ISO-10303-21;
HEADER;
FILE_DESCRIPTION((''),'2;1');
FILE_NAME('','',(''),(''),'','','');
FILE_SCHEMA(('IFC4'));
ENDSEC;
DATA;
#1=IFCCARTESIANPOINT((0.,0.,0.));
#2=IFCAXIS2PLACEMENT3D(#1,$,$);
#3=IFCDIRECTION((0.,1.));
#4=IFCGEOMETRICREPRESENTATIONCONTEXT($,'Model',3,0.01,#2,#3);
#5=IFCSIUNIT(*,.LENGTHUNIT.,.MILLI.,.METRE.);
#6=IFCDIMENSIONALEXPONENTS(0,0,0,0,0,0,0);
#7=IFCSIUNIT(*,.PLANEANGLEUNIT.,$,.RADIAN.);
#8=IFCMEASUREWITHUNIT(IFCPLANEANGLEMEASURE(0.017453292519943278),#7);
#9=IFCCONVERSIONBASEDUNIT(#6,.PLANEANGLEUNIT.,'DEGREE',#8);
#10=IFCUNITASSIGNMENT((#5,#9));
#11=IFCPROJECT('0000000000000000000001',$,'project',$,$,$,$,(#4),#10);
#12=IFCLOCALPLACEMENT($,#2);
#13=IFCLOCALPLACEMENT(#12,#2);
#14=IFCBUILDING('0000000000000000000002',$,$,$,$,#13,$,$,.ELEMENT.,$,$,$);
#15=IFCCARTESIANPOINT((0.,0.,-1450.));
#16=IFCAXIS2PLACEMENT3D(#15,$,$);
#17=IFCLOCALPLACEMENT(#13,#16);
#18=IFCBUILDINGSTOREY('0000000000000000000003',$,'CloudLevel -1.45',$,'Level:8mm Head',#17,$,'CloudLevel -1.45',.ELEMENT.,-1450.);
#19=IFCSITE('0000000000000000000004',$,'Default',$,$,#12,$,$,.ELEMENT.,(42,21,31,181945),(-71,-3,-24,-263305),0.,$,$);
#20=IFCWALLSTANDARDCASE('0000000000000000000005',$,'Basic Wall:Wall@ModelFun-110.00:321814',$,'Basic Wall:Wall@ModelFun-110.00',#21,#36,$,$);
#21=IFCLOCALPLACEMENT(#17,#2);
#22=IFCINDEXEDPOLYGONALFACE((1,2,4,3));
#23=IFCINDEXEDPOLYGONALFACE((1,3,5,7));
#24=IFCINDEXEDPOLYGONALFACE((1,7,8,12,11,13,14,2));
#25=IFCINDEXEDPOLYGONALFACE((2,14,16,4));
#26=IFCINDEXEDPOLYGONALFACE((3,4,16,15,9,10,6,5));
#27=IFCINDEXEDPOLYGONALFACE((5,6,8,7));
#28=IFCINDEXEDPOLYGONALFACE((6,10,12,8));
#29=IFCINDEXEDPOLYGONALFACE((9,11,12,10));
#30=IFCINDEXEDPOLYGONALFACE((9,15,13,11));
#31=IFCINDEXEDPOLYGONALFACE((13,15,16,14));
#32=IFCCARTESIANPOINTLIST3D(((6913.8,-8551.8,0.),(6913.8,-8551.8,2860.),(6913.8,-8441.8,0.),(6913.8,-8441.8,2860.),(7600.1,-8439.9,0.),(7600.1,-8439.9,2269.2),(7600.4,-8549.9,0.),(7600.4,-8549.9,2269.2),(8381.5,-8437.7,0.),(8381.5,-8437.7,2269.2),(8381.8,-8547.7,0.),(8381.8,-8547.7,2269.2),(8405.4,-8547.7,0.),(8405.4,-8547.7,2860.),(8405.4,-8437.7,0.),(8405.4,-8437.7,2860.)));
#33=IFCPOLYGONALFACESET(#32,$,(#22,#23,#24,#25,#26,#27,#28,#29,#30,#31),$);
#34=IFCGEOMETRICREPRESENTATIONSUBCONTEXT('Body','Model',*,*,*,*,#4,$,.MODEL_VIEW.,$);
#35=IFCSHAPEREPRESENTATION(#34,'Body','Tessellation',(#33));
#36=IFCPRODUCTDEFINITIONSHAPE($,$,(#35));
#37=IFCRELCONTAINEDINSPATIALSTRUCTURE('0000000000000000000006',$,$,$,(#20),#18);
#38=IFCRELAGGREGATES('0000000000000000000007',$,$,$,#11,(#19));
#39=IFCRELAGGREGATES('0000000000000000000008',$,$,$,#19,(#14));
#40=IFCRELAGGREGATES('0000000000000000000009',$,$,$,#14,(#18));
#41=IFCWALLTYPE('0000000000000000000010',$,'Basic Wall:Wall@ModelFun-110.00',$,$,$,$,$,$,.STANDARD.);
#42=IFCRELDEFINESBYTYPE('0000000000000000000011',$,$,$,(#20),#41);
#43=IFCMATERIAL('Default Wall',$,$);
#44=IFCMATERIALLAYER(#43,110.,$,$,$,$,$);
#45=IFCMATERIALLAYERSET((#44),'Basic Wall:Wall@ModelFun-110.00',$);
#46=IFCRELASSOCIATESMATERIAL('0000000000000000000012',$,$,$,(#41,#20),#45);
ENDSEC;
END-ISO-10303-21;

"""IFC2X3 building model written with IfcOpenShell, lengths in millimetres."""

from ifc_helpers import new_model, entity, si_unit, converted_unit, direction, frame, frame_2d, origin, place, context, subcontext, project, spatial, polyline, rectangle, outline, extrude, material, layer, layer_set, layer_usage, type_object, element, save


model = new_model("IFC2X3")

# Units and contexts
model_context = context("Model", 3, precision=0.01, world=origin(), true_north=direction((0.0, 1.0)))
body_context = subcontext(model_context, "Body", "Model", "MODEL_VIEW")
ifc_project = project(units=[si_unit("LENGTHUNIT", "METRE", prefix="MILLI"), converted_unit("PLANEANGLEUNIT", "DEGREE", entity("IfcPlaneAngleMeasure", 0.017453292519943278), si_unit("PLANEANGLEUNIT", "RADIAN"), dimensions=[0, 0, 0, 0, 0, 0, 0])], contexts=[model_context])

# Site, building, storey
site_placement = place(None, origin())
site = spatial("IfcSite", under=ifc_project, at=site_placement, Name="Default", CompositionType="ELEMENT", RefLatitude=(42, 21, 31, 181945), RefLongitude=(-71, -3, -24, -263305), RefElevation=0.0)
building_placement = place(site_placement, origin())
building = spatial("IfcBuilding", under=site, at=building_placement, CompositionType="ELEMENT")
storey_placement = place(building_placement, frame((0.0, 0.0, -1450.0)))
storey = spatial("IfcBuildingStorey", under=building, at=storey_placement, Name="CloudLevel -1.45", ObjectType="Level:8mm Head", LongName="CloudLevel -1.45", CompositionType="ELEMENT", Elevation=-1450.0)

# Shared definitions
ifc_material_1 = material(Name="Default Wall")

# Wall, opening
ifc_layer_1 = layer(ifc_material_1, 110.0)
ifc_layer_set_1 = layer_set([ifc_layer_1], Name="Basic Wall:Wall@ModelFun-110.00")
ifc_layer_usage_1 = layer_usage(ifc_layer_set_1, "AXIS2", "NEGATIVE", 55.0)
wall_type_1 = type_object("IfcWallType", Name="Basic Wall:Wall@ModelFun-110.00", PredefinedType="STANDARD", material=ifc_layer_set_1)
wall_1_placement = place(storey_placement, frame((6913.6, -8496.9, 0.0), z_axis=(0.0, 0.0, 1.0), x_axis=(0.999996, 0.002805, 0.0)))
wall_1 = element("IfcWallStandardCase", 1, at=wall_1_placement, inside=storey, type_object=wall_type_1, material=ifc_layer_usage_1, Name="Basic Wall:Wall@ModelFun-110.00:321814", ObjectType="Basic Wall:Wall@ModelFun-110.00", context=body_context, shape_type="SweptSolid", body=[
    extrude(outline(polyline([(0.0, -55.0), (1491.6, -55.0), (1492.0, 55.0), (0.3, 55.0), (0.0, -55.0)])), origin(), (0.0, 0.0, 1.0), 2860.0),
])
opening_1_placement = place(wall_1_placement, frame((686.6, -55.0, 0.0)))
element("IfcOpeningElement", 2, at=opening_1_placement, cuts=wall_1, ObjectType="Opening", context=body_context, shape_type="SweptSolid", body=[
    extrude(rectangle(XDim=781.4, YDim=2269.2, at=frame_2d((1134.6, 390.7), x_axis=(0.0, 1.0))), frame((0.0, 0.0, 0.0), z_axis=(0.0, 1.0, 0.0), x_axis=(0.0, 0.0, 1.0)), (0.0, 0.0, 1.0), 110.0),
])

save(model, "model.ifc")
